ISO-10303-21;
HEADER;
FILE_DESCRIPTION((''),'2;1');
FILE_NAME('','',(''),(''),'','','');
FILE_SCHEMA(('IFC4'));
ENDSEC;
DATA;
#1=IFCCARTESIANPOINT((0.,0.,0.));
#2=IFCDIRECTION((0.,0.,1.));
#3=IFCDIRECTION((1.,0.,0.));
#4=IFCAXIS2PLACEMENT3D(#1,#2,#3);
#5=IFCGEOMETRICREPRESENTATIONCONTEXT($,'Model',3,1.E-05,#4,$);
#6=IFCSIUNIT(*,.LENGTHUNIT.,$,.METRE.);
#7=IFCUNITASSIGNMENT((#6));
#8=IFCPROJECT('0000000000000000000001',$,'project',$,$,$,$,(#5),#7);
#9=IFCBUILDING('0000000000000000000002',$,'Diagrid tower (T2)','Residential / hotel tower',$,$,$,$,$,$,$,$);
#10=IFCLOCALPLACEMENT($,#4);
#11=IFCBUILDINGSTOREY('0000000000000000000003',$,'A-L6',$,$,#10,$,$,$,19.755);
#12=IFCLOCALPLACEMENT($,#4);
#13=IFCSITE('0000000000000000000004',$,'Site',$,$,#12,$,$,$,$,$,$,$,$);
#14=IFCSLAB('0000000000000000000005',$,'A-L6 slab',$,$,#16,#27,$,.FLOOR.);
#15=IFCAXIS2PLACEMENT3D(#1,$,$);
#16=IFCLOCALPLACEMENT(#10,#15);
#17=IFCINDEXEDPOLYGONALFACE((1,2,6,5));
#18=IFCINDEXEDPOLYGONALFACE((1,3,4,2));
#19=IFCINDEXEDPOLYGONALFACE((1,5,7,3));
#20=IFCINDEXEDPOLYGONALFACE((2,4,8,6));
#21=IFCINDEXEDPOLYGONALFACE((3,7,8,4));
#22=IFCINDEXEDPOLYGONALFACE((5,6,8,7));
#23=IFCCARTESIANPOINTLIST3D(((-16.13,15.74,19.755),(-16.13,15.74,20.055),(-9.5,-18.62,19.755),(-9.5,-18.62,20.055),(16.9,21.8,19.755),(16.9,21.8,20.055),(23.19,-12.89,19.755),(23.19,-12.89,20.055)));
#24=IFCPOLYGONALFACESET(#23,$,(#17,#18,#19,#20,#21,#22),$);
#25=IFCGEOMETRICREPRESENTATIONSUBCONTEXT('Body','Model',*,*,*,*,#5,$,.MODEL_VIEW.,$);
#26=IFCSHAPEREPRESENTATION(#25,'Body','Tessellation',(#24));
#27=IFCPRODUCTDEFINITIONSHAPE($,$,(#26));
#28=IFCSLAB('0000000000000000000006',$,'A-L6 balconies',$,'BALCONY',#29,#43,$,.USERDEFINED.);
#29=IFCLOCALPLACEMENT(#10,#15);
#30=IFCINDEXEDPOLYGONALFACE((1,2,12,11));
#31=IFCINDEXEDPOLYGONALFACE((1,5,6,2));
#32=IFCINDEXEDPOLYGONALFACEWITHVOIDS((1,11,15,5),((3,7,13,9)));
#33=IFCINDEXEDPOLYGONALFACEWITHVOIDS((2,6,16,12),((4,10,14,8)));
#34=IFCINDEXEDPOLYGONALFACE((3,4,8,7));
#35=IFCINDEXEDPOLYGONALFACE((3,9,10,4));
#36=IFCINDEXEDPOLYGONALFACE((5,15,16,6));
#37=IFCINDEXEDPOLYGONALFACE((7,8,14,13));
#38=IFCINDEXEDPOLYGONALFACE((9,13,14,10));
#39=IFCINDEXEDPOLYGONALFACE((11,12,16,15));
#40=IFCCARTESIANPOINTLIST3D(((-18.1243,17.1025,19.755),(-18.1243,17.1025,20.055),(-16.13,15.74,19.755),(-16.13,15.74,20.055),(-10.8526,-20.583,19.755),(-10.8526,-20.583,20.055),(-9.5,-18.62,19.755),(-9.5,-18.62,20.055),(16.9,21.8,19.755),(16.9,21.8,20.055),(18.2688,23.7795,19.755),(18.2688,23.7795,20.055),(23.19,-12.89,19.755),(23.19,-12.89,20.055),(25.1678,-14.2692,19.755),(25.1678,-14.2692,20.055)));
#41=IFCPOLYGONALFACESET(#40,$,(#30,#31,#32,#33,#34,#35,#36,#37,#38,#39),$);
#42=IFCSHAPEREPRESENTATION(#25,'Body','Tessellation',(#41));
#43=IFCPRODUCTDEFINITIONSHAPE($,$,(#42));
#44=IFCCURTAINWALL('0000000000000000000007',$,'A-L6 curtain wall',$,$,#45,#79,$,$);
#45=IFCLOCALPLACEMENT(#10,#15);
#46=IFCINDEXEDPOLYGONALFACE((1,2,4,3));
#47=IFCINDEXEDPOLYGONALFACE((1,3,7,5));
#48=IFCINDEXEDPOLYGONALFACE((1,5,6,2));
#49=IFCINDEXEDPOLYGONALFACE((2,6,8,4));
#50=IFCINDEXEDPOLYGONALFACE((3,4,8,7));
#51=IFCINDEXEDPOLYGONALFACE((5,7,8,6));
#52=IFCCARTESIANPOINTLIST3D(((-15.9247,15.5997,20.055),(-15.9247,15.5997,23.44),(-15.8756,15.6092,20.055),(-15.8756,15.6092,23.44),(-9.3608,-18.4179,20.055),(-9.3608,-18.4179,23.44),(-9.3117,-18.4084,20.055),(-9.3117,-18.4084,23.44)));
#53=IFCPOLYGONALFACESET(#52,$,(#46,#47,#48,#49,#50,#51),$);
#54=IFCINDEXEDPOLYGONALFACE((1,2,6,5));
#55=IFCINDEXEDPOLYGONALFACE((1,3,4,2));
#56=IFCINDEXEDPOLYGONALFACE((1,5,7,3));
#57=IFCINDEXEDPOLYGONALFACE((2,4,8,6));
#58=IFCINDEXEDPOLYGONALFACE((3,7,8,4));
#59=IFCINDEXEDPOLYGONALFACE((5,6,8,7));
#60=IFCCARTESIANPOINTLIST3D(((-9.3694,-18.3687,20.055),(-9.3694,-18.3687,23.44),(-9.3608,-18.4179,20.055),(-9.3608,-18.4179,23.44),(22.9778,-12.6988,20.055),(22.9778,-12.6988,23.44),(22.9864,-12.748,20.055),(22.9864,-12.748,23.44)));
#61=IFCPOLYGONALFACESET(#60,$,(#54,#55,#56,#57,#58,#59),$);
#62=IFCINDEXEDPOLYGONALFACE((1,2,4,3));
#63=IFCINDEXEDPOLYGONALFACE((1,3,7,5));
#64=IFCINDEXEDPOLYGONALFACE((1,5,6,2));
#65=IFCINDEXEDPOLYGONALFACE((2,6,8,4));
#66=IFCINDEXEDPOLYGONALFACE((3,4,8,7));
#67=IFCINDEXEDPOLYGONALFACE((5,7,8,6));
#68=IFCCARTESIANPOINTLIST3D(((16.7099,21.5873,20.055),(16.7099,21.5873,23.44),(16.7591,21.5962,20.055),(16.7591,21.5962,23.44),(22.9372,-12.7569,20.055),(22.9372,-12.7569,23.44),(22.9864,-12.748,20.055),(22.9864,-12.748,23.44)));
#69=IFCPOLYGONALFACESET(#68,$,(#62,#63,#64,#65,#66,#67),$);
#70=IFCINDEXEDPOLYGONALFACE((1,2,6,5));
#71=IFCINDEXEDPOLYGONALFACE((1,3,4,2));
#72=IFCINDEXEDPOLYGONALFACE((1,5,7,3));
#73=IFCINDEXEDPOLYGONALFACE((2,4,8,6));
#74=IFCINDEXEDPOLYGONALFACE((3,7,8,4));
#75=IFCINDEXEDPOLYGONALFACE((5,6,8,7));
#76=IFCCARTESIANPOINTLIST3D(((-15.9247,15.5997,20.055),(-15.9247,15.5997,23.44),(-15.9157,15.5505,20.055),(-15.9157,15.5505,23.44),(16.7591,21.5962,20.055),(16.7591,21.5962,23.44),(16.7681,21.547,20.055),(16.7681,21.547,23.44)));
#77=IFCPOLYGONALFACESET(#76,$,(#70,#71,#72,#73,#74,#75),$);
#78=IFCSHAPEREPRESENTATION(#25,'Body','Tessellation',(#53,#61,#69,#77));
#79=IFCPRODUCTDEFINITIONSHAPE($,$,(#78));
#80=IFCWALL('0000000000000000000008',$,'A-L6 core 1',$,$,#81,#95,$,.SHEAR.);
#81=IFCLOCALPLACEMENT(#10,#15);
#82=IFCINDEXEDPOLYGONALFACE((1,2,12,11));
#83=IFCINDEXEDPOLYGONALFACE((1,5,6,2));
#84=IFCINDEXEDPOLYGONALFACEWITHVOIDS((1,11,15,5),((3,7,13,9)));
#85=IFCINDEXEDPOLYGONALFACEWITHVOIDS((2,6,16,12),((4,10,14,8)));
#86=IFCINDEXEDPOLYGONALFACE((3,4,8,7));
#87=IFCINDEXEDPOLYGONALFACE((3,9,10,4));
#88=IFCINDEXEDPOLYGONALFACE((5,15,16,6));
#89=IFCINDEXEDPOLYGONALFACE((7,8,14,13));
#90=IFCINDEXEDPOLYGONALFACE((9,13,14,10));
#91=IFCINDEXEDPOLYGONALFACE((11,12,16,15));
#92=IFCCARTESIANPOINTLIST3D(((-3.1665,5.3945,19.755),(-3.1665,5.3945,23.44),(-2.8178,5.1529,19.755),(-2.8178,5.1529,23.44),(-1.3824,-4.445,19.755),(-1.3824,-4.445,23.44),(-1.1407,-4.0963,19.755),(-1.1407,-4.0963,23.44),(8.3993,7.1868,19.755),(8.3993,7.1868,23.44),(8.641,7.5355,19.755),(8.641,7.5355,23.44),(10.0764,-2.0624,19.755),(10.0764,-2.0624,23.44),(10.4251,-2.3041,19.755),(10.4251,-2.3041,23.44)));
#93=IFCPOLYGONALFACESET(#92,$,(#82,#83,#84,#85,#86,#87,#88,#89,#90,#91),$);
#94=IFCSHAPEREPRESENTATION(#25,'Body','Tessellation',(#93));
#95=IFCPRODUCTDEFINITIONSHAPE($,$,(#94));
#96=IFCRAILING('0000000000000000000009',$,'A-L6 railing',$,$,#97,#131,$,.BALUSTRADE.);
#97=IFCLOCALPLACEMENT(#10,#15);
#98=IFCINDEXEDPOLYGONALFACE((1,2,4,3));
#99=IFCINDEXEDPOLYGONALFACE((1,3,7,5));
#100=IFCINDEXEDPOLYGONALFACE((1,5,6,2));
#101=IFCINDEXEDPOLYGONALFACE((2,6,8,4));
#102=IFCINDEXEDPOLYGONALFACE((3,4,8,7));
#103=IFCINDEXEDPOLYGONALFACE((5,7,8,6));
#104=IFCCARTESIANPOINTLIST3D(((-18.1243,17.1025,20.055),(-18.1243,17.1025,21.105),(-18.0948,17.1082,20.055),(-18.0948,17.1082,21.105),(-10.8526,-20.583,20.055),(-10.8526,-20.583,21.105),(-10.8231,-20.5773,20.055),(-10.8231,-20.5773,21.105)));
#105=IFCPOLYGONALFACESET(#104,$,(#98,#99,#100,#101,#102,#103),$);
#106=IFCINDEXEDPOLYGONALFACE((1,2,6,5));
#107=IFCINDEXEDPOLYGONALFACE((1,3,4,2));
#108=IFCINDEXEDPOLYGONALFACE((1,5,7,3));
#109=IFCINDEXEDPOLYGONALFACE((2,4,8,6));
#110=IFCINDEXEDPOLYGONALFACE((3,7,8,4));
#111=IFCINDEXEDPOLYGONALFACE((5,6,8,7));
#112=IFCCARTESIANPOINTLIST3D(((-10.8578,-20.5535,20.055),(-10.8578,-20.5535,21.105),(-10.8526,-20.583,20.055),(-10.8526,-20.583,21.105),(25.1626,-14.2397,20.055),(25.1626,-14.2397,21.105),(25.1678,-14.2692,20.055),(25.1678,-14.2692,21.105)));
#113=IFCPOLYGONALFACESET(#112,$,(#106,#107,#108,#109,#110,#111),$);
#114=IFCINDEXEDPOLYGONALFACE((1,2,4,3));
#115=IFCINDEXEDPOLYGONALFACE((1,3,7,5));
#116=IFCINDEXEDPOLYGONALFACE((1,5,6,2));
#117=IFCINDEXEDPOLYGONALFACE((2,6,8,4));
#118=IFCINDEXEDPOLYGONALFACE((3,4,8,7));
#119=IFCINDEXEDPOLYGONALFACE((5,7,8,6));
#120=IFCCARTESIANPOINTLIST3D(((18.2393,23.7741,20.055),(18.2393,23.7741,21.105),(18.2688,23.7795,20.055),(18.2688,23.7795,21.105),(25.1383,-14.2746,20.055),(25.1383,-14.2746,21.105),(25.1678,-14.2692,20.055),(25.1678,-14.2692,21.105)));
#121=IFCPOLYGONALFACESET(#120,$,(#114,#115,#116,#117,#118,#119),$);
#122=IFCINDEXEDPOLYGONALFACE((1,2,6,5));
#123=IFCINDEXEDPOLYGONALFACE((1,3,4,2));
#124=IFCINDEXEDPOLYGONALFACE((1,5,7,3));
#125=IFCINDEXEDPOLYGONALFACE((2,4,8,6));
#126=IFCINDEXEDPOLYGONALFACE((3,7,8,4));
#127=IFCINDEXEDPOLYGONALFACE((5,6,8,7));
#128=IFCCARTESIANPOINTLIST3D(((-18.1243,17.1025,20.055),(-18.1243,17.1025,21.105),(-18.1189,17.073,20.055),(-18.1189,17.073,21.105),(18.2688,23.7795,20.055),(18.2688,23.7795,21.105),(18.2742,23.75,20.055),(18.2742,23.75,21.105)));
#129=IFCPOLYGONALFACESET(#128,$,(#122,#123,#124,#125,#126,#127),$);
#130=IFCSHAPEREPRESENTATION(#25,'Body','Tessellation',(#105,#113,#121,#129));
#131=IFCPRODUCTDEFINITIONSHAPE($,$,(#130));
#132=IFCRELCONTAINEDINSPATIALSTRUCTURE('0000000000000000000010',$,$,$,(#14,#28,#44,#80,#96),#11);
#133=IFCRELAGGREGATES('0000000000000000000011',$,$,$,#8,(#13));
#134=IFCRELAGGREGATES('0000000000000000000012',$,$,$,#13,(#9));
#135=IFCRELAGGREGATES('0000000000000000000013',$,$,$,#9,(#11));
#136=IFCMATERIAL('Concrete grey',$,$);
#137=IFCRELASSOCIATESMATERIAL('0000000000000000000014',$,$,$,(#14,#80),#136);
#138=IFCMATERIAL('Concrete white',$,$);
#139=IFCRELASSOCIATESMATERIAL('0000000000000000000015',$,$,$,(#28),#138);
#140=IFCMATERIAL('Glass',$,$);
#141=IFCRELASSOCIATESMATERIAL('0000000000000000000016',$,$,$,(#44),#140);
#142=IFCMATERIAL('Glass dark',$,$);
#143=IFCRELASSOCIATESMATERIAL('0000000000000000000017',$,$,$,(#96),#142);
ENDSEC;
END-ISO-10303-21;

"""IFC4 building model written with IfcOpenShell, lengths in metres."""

from ifc_helpers import new_model, si_unit, frame, origin_with_axes, place, context, subcontext, project, spatial, polyline, outline, extrude, material, element, save


model = new_model("IFC4")

# Units and contexts
model_context = context("Model", 3, precision=1e-05, world=origin_with_axes())
body_context = subcontext(model_context, "Body", "Model", "MODEL_VIEW")
ifc_project = project(units=[si_unit("LENGTHUNIT", "METRE")], contexts=[model_context])

# Site, building, storey
site_placement = place(None, origin_with_axes())
site = spatial("IfcSite", under=ifc_project, at=site_placement, Name="Site")
building = spatial("IfcBuilding", under=site, Name="Diagrid tower (T2)", Description="Residential / hotel tower")
storey_placement = place(None, origin_with_axes())
storey = spatial("IfcBuildingStorey", under=building, at=storey_placement, Name="A-L6", Elevation=19.755)

# Slabs
ifc_material_1 = material(Name="Concrete grey")
slab_1_placement = place(storey_placement, origin_with_axes())
element("IfcSlab", 1, at=slab_1_placement, inside=storey, material=ifc_material_1, Name="A-L6 slab", PredefinedType="FLOOR", context=body_context, shape_type="SweptSolid", body=[
    extrude(outline(polyline([(-16.13, 15.74), (-9.5, -18.62), (23.19, -12.89), (16.9, 21.8), (-16.13, 15.74)])), frame((0.0, 0.0, 19.755), z_axis=(0.0, 0.0, 1.0), x_axis=(1.0, 0.0, 0.0)), (0.0, 0.0, 1.0), 0.3),
])
ifc_material_2 = material(Name="Concrete white")
slab_2_placement = place(storey_placement, origin_with_axes())
element("IfcSlab", 2, at=slab_2_placement, inside=storey, material=ifc_material_2, Name="A-L6 balconies", ObjectType="BALCONY", PredefinedType="USERDEFINED", context=body_context, shape_type="SweptSolid", body=[
    extrude(outline(polyline([(-18.1243, 17.1025), (-10.8526, -20.583), (25.1678, -14.2692), (18.2688, 23.7795), (-18.1243, 17.1025)]), holes=[polyline([(-16.13, 15.74), (-9.5, -18.62), (23.19, -12.89), (16.9, 21.8), (-16.13, 15.74)])]), frame((0.0, 0.0, 19.755), z_axis=(0.0, 0.0, 1.0), x_axis=(1.0, 0.0, 0.0)), (0.0, 0.0, 1.0), 0.3),
])

# Curtain wall
ifc_material_3 = material(Name="Glass")
curtain_wall_placement = place(storey_placement, origin_with_axes())
element("IfcCurtainWall", 3, at=curtain_wall_placement, inside=storey, material=ifc_material_3, Name="A-L6 curtain wall", context=body_context, shape_type="SweptSolid", body=[
    extrude(outline(polyline([(-15.9247, 15.5997), (-9.3608, -18.4179), (-9.3117, -18.4084), (-15.8756, 15.6092), (-15.9247, 15.5997)])), frame((0.0, 0.0, 20.055), z_axis=(0.0, 0.0, 1.0), x_axis=(1.0, 0.0, 0.0)), (0.0, 0.0, 1.0), 3.385),
    extrude(outline(polyline([(-9.3608, -18.4179), (22.9864, -12.748), (22.9778, -12.6988), (-9.3694, -18.3687), (-9.3608, -18.4179)])), frame((0.0, 0.0, 20.055), z_axis=(0.0, 0.0, 1.0), x_axis=(1.0, 0.0, 0.0)), (0.0, 0.0, 1.0), 3.385),
    extrude(outline(polyline([(22.9864, -12.748), (16.7591, 21.5962), (16.7099, 21.5873), (22.9372, -12.7569), (22.9864, -12.748)])), frame((0.0, 0.0, 20.055), z_axis=(0.0, 0.0, 1.0), x_axis=(1.0, 0.0, 0.0)), (0.0, 0.0, 1.0), 3.385),
    extrude(outline(polyline([(16.7591, 21.5962), (-15.9247, 15.5997), (-15.9157, 15.5505), (16.7681, 21.547), (16.7591, 21.5962)])), frame((0.0, 0.0, 20.055), z_axis=(0.0, 0.0, 1.0), x_axis=(1.0, 0.0, 0.0)), (0.0, 0.0, 1.0), 3.385),
])

# Wall
wall_placement = place(storey_placement, origin_with_axes())
element("IfcWall", 4, at=wall_placement, inside=storey, material=ifc_material_1, Name="A-L6 core 1", PredefinedType="SHEAR", context=body_context, shape_type="SweptSolid", body=[
    extrude(outline(polyline([(10.4251, -2.3041), (8.641, 7.5355), (-3.1665, 5.3945), (-1.3824, -4.445), (10.4251, -2.3041)]), holes=[polyline([(10.0764, -2.0624), (8.3993, 7.1868), (-2.8178, 5.1529), (-1.1407, -4.0963), (10.0764, -2.0624)])]), frame((0.0, 0.0, 19.755), z_axis=(0.0, 0.0, 1.0), x_axis=(1.0, 0.0, 0.0)), (0.0, 0.0, 1.0), 3.685),
])

# Railing
ifc_material_4 = material(Name="Glass dark")
railing_placement = place(storey_placement, origin_with_axes())
element("IfcRailing", 5, at=railing_placement, inside=storey, material=ifc_material_4, Name="A-L6 railing", PredefinedType="BALUSTRADE", context=body_context, shape_type="SweptSolid", body=[
    extrude(outline(polyline([(-18.1243, 17.1025), (-10.8526, -20.583), (-10.8231, -20.5773), (-18.0948, 17.1082), (-18.1243, 17.1025)])), frame((0.0, 0.0, 20.055), z_axis=(0.0, 0.0, 1.0), x_axis=(1.0, 0.0, 0.0)), (0.0, 0.0, 1.0), 1.05),
    extrude(outline(polyline([(-10.8526, -20.583), (25.1678, -14.2692), (25.1626, -14.2397), (-10.8578, -20.5535), (-10.8526, -20.583)])), frame((0.0, 0.0, 20.055), z_axis=(0.0, 0.0, 1.0), x_axis=(1.0, 0.0, 0.0)), (0.0, 0.0, 1.0), 1.05),
    extrude(outline(polyline([(25.1678, -14.2692), (18.2688, 23.7795), (18.2393, 23.7741), (25.1383, -14.2746), (25.1678, -14.2692)])), frame((0.0, 0.0, 20.055), z_axis=(0.0, 0.0, 1.0), x_axis=(1.0, 0.0, 0.0)), (0.0, 0.0, 1.0), 1.05),
    extrude(outline(polyline([(18.2688, 23.7795), (-18.1243, 17.1025), (-18.1189, 17.073), (18.2742, 23.75), (18.2688, 23.7795)])), frame((0.0, 0.0, 20.055), z_axis=(0.0, 0.0, 1.0), x_axis=(1.0, 0.0, 0.0)), (0.0, 0.0, 1.0), 1.05),
])

save(model, "model.ifc")
